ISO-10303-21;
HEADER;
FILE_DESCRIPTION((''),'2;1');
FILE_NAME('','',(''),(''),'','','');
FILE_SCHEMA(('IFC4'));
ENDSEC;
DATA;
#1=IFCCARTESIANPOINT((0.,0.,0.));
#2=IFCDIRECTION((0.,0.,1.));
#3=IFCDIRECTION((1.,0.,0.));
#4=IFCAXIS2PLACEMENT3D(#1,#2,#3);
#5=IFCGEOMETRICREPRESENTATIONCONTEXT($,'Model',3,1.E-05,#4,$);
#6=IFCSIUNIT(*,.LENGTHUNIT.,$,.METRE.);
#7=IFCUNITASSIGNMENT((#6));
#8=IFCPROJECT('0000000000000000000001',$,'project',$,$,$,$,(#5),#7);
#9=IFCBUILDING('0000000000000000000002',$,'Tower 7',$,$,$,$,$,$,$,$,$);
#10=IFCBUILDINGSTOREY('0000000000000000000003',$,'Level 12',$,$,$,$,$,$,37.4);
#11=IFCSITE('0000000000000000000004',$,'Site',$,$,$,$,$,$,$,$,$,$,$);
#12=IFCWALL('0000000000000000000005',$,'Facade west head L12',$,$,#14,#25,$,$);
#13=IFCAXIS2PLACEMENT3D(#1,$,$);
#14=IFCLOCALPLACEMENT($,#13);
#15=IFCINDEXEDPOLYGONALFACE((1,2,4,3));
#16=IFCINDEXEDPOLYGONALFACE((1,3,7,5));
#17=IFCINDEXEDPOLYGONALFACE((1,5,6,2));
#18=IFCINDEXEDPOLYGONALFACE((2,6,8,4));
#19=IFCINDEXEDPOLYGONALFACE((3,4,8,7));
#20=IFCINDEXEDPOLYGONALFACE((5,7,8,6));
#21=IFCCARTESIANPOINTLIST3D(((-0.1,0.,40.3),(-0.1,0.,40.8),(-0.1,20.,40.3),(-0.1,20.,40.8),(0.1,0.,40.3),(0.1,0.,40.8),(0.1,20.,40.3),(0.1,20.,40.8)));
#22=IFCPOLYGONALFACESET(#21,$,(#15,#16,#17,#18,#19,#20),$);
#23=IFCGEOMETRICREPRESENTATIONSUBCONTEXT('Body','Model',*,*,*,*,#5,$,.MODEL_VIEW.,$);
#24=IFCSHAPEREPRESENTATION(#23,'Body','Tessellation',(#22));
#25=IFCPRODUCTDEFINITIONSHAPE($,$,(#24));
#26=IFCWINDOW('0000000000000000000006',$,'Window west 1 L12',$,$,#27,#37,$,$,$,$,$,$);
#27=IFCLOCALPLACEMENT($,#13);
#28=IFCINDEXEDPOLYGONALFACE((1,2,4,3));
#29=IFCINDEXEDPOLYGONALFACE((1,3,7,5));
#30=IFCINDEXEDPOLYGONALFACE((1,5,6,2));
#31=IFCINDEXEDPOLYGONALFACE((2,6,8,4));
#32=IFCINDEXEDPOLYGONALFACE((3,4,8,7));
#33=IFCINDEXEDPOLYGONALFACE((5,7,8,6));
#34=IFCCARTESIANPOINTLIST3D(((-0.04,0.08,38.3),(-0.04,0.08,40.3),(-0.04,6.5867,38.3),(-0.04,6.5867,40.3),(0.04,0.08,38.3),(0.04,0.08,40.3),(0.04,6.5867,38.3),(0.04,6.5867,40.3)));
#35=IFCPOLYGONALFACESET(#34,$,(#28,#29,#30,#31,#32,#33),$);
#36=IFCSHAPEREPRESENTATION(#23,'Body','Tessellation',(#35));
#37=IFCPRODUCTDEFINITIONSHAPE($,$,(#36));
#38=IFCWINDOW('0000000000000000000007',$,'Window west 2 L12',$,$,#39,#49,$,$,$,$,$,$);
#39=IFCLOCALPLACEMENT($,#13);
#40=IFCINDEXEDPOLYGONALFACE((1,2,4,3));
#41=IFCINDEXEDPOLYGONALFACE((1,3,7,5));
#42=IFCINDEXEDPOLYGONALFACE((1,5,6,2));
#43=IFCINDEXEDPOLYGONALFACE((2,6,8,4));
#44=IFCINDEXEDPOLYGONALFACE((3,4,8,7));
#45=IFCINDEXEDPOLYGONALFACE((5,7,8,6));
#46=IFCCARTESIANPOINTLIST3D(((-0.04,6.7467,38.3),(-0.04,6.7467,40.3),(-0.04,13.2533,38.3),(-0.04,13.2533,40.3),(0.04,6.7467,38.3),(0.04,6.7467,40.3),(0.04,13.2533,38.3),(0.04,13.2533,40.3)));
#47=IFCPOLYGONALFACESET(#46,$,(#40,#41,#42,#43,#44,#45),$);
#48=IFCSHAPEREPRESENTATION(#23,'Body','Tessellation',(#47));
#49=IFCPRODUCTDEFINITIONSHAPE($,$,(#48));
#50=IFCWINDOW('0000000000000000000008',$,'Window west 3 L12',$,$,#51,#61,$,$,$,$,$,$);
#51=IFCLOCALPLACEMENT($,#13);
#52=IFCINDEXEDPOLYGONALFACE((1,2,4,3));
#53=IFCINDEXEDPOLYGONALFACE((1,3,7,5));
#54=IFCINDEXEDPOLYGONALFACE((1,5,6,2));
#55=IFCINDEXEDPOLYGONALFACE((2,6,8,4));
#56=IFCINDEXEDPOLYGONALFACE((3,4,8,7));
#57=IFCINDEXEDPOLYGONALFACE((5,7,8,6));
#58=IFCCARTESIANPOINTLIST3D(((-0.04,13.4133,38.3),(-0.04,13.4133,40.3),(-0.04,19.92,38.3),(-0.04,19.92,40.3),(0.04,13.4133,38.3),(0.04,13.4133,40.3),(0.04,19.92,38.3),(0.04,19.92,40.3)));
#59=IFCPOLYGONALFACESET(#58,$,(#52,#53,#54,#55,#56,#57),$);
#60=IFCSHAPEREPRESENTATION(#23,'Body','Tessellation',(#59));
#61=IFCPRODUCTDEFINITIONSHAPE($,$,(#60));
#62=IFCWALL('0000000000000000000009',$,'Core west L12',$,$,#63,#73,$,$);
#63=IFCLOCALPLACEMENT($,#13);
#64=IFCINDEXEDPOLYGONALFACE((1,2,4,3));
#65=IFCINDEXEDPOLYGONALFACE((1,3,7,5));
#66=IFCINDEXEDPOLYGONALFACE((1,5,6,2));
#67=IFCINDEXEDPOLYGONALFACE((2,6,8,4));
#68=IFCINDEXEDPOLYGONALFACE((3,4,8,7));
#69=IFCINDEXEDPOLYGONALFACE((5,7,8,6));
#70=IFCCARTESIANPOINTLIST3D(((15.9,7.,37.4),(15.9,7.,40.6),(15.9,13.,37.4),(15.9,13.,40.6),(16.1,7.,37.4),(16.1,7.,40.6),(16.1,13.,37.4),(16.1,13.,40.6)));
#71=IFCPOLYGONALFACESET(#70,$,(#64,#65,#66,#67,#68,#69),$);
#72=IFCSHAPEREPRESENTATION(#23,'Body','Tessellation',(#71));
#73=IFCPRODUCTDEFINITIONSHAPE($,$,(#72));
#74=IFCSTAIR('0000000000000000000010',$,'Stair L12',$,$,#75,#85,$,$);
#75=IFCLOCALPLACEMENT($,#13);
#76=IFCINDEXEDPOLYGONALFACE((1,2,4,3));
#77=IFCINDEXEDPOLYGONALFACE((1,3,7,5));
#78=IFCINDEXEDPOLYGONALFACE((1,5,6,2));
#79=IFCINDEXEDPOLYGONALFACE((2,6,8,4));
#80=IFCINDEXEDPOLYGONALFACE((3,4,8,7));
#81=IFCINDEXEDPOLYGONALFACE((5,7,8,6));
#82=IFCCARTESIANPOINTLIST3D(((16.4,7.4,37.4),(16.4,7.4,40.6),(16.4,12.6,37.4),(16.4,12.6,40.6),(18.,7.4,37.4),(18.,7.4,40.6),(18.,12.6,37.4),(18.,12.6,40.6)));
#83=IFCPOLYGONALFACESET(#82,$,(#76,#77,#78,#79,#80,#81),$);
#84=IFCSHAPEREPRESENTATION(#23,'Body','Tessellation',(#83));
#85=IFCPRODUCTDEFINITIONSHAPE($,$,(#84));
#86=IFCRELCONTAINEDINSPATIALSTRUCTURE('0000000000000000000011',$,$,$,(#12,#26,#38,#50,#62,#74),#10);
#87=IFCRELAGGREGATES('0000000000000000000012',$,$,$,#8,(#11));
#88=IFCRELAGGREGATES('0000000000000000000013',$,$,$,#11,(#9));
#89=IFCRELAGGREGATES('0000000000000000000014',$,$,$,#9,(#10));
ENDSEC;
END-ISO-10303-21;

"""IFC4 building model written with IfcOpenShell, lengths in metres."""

from ifc_helpers import new_model, si_unit, frame, origin, origin_with_axes, origin_2d, place, context, subcontext, project, spatial, rectangle, extrude, element, save


model = new_model("IFC4")

# Units and contexts
model_context = context("Model", 3, precision=1e-05, world=origin_with_axes())
body_context = subcontext(model_context, "Body", "Model", "MODEL_VIEW")
ifc_project = project(units=[si_unit("LENGTHUNIT", "METRE")], contexts=[model_context])

# Site, building, storey
site = spatial("IfcSite", under=ifc_project, Name="Site")
building = spatial("IfcBuilding", under=site, Name="Tower 7")
storey = spatial("IfcBuildingStorey", under=building, Name="Level 12", Elevation=37.4)

# Wall
wall_1_placement = place(None, frame((0.0, 10.0, 40.3), z_axis=(0.0, 0.0, 1.0), x_axis=(1.0, 0.0, 0.0)))
element("IfcWall", 1, at=wall_1_placement, inside=storey, Name="Facade west head L12", context=body_context, shape_type="SweptSolid", body=[
    extrude(rectangle(XDim=0.2, YDim=20.0, at=origin_2d()), origin(), (0.0, 0.0, 1.0), 0.5),
])

# Windows
for number, where, z_axis, x_axis, name in (
    (2, (0.0, 3.3333, 38.3), (0.0, 0.0, 1.0), (1.0, 0.0, 0.0), "Window west 1 L12"),
    (3, (0.0, 10.0, 38.3), (0.0, 0.0, 1.0), (1.0, 0.0, 0.0), "Window west 2 L12"),
):
    element("IfcWindow", number, at=place(None, frame(where, z_axis=z_axis, x_axis=x_axis)), inside=storey, Name=name, context=body_context, shape_type="SweptSolid", body=[
        extrude(rectangle(XDim=0.08, YDim=6.5067, at=origin_2d()), origin(), (0.0, 0.0, 1.0), 2.0),
    ])
window_1_placement = place(None, frame((0.0, 16.6667, 38.3), z_axis=(0.0, 0.0, 1.0), x_axis=(1.0, 0.0, 0.0)))
element("IfcWindow", 4, at=window_1_placement, inside=storey, Name="Window west 3 L12", context=body_context, shape_type="SweptSolid", body=[
    extrude(rectangle(XDim=0.08, YDim=6.5067, at=origin_2d()), origin(), (0.0, 0.0, 1.0), 2.0),
])

# Wall
wall_2_placement = place(None, frame((16.0, 10.0, 37.4), z_axis=(0.0, 0.0, 1.0), x_axis=(1.0, 0.0, 0.0)))
element("IfcWall", 5, at=wall_2_placement, inside=storey, Name="Core west L12", context=body_context, shape_type="SweptSolid", body=[
    extrude(rectangle(XDim=0.2, YDim=6.0, at=origin_2d()), origin(), (0.0, 0.0, 1.0), 3.2),
])

# Stair
stair_placement = place(None, frame((17.2, 10.0, 37.4), z_axis=(0.0, 0.0, 1.0), x_axis=(1.0, 0.0, 0.0)))
element("IfcStair", 6, at=stair_placement, inside=storey, Name="Stair L12", context=body_context, shape_type="SweptSolid", body=[
    extrude(rectangle(XDim=1.6, YDim=5.2, at=origin_2d()), origin(), (0.0, 0.0, 1.0), 3.2),
])

save(model, "model.ifc")
